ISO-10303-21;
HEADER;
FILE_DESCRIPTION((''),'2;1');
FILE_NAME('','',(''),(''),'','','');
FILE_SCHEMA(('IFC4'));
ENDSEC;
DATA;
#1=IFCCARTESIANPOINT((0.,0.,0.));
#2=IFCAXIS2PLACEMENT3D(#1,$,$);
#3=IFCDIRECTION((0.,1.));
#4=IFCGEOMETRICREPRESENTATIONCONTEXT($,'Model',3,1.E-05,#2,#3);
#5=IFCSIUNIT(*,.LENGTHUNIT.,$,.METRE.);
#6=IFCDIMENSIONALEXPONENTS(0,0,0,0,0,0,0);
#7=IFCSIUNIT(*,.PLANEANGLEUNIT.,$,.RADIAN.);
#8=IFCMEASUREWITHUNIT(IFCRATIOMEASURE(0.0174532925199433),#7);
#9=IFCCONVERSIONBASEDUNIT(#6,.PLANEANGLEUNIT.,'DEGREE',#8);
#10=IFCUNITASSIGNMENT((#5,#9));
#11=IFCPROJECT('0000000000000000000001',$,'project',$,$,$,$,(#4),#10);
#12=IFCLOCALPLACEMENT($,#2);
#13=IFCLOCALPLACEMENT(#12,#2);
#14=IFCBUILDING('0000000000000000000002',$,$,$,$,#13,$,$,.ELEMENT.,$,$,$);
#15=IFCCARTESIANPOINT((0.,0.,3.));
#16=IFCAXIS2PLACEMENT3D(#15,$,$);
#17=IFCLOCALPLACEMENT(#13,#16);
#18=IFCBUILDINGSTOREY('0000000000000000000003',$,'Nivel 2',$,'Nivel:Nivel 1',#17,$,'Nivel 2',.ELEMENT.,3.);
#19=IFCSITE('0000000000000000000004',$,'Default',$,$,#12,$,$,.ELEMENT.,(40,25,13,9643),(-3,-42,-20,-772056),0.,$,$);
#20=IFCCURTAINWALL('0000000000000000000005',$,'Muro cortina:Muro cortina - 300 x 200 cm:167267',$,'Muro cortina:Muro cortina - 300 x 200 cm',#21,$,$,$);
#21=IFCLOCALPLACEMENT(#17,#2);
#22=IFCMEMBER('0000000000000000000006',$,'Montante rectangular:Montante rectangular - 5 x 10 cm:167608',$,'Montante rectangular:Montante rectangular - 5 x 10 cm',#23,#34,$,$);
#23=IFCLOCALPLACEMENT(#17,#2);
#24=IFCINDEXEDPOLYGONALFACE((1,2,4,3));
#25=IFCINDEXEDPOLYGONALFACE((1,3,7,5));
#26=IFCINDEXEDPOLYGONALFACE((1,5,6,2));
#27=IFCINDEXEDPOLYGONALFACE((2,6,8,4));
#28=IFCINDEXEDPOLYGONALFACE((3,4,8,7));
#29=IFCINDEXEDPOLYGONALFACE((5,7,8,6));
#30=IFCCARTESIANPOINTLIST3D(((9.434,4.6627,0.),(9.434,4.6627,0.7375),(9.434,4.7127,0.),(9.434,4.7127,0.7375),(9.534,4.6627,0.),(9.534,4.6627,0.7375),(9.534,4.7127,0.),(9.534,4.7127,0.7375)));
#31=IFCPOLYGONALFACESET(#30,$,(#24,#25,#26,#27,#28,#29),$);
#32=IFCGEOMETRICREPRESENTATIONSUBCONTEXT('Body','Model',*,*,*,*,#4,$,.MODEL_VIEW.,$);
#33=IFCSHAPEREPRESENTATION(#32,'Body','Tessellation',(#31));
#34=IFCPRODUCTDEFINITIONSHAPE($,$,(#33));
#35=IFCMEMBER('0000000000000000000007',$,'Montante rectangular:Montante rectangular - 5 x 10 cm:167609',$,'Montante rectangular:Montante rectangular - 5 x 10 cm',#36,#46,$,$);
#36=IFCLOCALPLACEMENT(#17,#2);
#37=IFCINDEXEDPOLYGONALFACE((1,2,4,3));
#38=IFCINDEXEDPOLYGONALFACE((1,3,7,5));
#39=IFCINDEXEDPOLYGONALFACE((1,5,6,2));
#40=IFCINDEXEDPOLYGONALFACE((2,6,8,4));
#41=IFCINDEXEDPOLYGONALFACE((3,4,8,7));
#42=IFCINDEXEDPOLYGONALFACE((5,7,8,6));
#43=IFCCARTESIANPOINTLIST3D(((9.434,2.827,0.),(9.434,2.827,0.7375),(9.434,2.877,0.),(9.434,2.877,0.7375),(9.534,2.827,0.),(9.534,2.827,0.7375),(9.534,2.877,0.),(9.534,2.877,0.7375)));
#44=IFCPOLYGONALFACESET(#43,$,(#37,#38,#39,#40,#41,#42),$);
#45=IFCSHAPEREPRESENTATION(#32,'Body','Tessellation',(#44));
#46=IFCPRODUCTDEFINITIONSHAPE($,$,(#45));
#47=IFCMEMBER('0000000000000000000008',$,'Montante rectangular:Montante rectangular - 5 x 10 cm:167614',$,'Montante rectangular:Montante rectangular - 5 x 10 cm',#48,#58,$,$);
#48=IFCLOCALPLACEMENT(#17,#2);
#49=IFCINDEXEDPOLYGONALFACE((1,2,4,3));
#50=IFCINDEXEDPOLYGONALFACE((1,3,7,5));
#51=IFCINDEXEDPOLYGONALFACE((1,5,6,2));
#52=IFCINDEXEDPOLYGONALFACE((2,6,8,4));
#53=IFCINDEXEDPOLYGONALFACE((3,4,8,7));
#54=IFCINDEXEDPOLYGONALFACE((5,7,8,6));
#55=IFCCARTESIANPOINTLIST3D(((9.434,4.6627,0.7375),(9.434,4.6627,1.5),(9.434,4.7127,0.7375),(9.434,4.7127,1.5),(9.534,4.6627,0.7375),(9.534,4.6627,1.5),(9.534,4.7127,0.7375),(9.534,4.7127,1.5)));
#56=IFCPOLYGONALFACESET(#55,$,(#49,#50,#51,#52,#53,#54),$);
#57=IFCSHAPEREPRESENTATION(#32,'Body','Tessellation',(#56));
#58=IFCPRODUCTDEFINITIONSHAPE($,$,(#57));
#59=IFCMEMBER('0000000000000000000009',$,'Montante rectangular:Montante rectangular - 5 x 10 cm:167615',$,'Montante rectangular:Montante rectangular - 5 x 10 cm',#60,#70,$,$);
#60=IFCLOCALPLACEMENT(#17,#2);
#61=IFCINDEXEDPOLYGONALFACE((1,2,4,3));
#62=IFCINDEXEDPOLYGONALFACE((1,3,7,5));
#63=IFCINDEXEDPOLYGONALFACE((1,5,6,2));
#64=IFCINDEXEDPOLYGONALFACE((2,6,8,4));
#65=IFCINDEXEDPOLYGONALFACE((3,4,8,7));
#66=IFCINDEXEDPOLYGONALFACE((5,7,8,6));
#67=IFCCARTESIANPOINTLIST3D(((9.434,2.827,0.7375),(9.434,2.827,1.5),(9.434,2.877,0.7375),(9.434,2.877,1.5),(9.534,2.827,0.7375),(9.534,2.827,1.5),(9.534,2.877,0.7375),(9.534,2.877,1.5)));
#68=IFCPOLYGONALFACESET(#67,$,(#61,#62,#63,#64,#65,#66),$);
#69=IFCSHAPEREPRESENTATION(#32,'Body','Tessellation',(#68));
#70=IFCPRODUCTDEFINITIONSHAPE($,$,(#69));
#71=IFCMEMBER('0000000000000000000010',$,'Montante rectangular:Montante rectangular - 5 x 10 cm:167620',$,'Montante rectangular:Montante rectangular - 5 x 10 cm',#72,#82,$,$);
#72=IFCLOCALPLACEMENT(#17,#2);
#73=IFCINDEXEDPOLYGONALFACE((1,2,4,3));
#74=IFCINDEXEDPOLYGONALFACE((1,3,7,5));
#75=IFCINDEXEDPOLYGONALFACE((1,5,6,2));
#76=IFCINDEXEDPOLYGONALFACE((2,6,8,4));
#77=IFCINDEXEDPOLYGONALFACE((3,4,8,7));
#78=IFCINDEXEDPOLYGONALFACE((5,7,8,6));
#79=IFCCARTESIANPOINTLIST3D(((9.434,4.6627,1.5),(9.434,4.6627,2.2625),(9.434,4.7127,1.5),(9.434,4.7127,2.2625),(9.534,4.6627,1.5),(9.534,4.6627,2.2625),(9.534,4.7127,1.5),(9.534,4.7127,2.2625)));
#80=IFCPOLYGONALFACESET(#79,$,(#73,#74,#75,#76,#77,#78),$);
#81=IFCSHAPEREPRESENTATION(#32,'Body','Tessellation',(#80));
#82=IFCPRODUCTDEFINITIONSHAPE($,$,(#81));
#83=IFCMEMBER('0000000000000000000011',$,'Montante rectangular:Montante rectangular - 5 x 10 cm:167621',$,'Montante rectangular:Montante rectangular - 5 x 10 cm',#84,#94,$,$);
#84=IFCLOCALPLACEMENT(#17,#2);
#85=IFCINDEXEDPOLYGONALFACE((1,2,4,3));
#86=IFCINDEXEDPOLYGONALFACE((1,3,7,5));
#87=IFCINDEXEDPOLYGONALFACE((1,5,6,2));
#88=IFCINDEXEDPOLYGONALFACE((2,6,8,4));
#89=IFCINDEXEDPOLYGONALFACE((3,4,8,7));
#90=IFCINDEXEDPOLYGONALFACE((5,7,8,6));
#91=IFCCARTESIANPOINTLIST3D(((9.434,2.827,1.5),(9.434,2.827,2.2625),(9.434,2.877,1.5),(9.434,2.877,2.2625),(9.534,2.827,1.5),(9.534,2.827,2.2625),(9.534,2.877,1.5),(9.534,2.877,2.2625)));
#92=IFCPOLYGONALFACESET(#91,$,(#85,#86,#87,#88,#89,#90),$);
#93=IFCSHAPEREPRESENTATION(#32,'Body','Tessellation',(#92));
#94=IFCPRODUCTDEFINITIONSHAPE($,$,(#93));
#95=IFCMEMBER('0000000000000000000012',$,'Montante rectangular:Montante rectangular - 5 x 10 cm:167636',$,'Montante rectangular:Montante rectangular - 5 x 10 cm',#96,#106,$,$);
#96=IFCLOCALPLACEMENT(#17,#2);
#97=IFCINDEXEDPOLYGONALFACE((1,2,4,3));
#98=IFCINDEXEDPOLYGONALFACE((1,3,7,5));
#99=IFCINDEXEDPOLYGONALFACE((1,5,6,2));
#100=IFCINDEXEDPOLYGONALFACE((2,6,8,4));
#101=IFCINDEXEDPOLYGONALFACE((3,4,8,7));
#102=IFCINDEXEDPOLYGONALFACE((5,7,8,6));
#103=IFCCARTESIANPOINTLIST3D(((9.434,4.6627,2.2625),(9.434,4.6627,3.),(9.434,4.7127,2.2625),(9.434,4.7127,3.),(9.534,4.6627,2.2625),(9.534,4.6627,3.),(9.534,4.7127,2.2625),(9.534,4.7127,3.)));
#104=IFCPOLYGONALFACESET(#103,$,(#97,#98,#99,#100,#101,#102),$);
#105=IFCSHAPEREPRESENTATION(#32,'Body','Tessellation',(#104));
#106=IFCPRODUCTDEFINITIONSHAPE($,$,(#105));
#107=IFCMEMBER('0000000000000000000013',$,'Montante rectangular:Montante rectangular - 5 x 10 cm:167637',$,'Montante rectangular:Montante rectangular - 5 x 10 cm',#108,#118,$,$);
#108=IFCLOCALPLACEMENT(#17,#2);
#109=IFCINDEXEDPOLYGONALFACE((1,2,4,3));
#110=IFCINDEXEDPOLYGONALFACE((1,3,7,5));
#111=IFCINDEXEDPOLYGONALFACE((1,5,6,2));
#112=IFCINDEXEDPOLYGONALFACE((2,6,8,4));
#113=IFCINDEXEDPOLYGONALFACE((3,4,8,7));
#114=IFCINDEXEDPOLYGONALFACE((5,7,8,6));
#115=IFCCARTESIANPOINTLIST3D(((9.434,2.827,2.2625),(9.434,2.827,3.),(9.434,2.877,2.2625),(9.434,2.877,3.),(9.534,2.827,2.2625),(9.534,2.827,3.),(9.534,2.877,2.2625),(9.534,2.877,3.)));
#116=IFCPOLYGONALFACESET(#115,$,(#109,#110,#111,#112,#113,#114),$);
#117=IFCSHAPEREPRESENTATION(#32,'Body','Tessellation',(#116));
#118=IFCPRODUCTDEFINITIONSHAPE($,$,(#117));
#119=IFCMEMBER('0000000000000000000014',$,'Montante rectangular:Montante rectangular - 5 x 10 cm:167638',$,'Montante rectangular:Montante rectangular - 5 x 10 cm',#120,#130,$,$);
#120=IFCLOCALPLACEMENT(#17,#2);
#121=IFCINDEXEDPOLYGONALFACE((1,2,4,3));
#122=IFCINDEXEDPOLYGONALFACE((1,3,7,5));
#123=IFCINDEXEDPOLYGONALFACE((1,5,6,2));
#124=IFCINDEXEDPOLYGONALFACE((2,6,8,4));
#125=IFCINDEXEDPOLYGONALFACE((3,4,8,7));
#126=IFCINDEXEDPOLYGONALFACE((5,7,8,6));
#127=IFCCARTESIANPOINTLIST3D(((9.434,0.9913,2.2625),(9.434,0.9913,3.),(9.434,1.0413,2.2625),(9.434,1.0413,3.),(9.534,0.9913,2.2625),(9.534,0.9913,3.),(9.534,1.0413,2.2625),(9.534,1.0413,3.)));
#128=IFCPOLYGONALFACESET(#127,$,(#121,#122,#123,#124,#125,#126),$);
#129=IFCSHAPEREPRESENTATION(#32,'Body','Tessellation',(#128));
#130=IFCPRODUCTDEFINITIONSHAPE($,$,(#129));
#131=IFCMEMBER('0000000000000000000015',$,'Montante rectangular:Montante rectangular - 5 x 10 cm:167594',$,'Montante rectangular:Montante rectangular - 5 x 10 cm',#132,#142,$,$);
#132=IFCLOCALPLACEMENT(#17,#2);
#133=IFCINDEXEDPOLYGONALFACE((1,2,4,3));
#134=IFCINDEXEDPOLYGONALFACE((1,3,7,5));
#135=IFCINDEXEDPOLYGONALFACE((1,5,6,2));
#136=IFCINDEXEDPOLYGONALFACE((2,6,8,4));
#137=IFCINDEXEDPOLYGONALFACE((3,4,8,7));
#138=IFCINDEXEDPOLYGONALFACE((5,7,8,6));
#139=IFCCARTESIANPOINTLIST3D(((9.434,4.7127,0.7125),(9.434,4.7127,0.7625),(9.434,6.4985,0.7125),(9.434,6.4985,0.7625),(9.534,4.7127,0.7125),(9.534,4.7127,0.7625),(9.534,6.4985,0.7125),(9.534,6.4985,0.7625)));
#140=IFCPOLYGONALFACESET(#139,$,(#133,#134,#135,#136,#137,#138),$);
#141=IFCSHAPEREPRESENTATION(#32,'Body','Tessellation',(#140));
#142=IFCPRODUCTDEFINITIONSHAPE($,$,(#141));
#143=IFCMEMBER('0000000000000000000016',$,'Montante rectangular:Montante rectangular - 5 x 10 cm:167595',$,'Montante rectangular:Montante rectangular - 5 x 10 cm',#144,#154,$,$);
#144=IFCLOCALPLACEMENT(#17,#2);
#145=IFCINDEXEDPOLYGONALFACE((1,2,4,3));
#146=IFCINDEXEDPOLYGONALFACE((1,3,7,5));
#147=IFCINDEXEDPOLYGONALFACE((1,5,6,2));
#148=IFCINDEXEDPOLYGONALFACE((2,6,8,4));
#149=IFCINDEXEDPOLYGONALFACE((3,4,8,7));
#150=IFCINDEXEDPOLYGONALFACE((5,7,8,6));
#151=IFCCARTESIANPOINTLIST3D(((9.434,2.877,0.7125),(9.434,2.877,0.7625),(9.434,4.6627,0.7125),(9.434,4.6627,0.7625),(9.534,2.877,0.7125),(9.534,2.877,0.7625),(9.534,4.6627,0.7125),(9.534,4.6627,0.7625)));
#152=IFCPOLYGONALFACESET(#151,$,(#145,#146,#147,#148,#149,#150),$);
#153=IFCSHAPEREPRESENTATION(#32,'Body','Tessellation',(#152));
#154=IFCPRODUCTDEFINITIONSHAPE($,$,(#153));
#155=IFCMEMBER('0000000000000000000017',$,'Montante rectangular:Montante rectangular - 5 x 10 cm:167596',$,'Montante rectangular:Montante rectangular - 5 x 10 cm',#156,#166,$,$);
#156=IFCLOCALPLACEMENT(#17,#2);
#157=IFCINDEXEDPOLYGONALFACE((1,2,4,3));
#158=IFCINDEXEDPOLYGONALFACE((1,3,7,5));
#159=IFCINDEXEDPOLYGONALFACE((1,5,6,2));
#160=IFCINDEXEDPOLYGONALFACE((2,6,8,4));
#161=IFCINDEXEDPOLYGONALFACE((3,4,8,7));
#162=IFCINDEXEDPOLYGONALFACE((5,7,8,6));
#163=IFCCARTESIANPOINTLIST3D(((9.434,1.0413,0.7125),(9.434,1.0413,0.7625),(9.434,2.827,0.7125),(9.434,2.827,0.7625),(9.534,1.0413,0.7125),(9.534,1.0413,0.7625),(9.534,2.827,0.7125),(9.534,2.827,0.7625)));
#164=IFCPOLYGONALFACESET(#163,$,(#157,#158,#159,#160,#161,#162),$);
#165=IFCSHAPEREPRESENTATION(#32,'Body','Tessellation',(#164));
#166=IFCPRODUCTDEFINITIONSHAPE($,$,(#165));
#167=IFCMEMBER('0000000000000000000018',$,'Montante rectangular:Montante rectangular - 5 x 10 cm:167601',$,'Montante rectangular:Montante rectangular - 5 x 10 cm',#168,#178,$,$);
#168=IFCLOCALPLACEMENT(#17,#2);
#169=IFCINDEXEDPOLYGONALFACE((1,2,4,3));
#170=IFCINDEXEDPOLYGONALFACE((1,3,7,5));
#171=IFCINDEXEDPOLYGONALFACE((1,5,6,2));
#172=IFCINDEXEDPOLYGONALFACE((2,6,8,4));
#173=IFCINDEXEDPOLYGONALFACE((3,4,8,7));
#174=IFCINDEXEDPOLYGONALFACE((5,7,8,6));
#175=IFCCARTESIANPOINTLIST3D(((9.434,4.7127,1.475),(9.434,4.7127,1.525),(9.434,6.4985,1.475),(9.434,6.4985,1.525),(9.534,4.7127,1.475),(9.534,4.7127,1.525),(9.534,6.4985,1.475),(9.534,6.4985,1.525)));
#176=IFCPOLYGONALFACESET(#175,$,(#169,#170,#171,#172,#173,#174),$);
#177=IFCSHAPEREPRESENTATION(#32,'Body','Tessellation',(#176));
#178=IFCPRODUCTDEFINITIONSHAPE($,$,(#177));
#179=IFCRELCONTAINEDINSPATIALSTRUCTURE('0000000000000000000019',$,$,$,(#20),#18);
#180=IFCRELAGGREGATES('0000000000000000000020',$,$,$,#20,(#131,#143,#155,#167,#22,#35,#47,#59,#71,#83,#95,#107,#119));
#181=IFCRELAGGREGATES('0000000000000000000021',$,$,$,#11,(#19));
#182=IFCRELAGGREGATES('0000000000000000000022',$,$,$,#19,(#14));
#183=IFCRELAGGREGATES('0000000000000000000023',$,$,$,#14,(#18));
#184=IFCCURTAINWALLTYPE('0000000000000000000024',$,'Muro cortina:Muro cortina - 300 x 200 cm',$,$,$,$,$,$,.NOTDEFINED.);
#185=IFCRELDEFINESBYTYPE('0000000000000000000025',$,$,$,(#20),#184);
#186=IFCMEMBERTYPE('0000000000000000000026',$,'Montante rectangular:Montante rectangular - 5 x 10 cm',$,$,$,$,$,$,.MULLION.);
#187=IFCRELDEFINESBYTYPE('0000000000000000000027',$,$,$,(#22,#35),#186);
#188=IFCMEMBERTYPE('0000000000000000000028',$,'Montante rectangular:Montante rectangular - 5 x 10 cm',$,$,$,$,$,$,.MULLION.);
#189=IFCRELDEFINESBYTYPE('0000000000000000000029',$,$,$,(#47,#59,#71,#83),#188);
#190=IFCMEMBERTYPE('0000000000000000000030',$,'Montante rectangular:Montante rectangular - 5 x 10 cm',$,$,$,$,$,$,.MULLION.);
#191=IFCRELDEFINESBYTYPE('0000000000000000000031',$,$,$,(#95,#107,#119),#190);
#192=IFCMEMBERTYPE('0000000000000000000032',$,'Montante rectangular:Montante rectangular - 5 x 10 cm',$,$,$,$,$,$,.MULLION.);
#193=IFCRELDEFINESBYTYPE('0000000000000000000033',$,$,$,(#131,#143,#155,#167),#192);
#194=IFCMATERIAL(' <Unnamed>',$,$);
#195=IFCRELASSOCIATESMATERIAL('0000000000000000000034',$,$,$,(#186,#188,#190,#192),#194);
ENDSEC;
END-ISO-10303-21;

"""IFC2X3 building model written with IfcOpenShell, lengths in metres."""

from ifc_helpers import new_model, entity, si_unit, converted_unit, direction, frame, origin, origin_2d_with_axis, place, context, subcontext, project, spatial, rectangle, extrude, source, transform, mapped, material, type_object, type_shapes, element, aggregate, save


model = new_model("IFC2X3")

# Units and contexts
model_context = context("Model", 3, precision=1e-05, world=origin(), true_north=direction((0.0, 1.0)))
body_context = subcontext(model_context, "Body", "Model", "MODEL_VIEW")
ifc_project = project(units=[si_unit("LENGTHUNIT", "METRE"), converted_unit("PLANEANGLEUNIT", "DEGREE", entity("IfcRatioMeasure", 0.0174532925199433), si_unit("PLANEANGLEUNIT", "RADIAN"), dimensions=[0, 0, 0, 0, 0, 0, 0])], contexts=[model_context])

# Site, building, storey
site_placement = place(None, origin())
site = spatial("IfcSite", under=ifc_project, at=site_placement, Name="Default", CompositionType="ELEMENT", RefLatitude=(40, 25, 13, 9643), RefLongitude=(-3, -42, -20, -772056), RefElevation=0.0)
building_placement = place(site_placement, origin())
building = spatial("IfcBuilding", under=site, at=building_placement, CompositionType="ELEMENT")
storey_placement = place(building_placement, frame((0.0, 0.0, 3.0)))
storey = spatial("IfcBuildingStorey", under=building, at=storey_placement, Name="Nivel 2", ObjectType="Nivel:Nivel 1", LongName="Nivel 2", CompositionType="ELEMENT", Elevation=3.0)

# Curtain wall, members
curtain_wall_type = type_object("IfcCurtainWallType", Name="Muro cortina:Muro cortina - 300 x 200 cm", PredefinedType="NOTDEFINED")
curtain_wall_placement = place(storey_placement, frame((0.0, 0.0, -3.0)))
curtain_wall = element("IfcCurtainWall", 1, at=curtain_wall_placement, inside=storey, type_object=curtain_wall_type, Name="Muro cortina:Muro cortina - 300 x 200 cm:167267", ObjectType="Muro cortina:Muro cortina - 300 x 200 cm")
ifc_material_1 = material(Name=" <Unnamed>")
member_type_1 = type_object("IfcMemberType", Name="Montante rectangular:Montante rectangular - 5 x 10 cm", PredefinedType="MULLION", material=ifc_material_1)
shared_shape_1 = source(origin(), body_context, "Body", "SweptSolid", [
    extrude(rectangle(XDim=0.1, YDim=0.05, at=origin_2d_with_axis()), frame((0.0, 0.0, -0.7375), z_axis=(0.0, 0.0, 1.0), x_axis=(0.0, -1.0, 0.0)), (0.0, 0.0, 1.0), 0.7375),
])
type_shapes(member_type_1, [shared_shape_1])
member_1_placement = place(storey_placement, frame((9.484, 4.6877, 0.0), z_axis=(0.0, 0.0, -1.0), x_axis=(0.0, -1.0, 0.0)))
member_1 = element("IfcMember", 2, at=member_1_placement, type_object=member_type_1, Name="Montante rectangular:Montante rectangular - 5 x 10 cm:167608", ObjectType="Montante rectangular:Montante rectangular - 5 x 10 cm", context=body_context, shape_type="MappedRepresentation", body=[
    mapped(shared_shape_1, transform((0.0, 0.0, 0.0), scale=1.0)),
])
member_2_placement = place(storey_placement, frame((9.484, 2.852, 0.0), z_axis=(0.0, 0.0, -1.0), x_axis=(0.0, -1.0, 0.0)))
member_2 = element("IfcMember", 3, at=member_2_placement, type_object=member_type_1, Name="Montante rectangular:Montante rectangular - 5 x 10 cm:167609", ObjectType="Montante rectangular:Montante rectangular - 5 x 10 cm", context=body_context, shape_type="MappedRepresentation", body=[
    mapped(shared_shape_1, transform((0.0, 0.0, 0.0), scale=1.0)),
])
member_type_2 = type_object("IfcMemberType", Name="Montante rectangular:Montante rectangular - 5 x 10 cm", PredefinedType="MULLION", material=ifc_material_1)
shared_shape_2 = source(origin(), body_context, "Body", "SweptSolid", [
    extrude(rectangle(XDim=0.1, YDim=0.05, at=origin_2d_with_axis()), frame((0.0, 0.0, -0.7625), z_axis=(0.0, 0.0, 1.0), x_axis=(0.0, -1.0, 0.0)), (0.0, 0.0, 1.0), 0.7625),
])
type_shapes(member_type_2, [shared_shape_2])
member_3_placement = place(storey_placement, frame((9.484, 4.6877, 0.7375), z_axis=(0.0, 0.0, -1.0), x_axis=(0.0, -1.0, 0.0)))
member_3 = element("IfcMember", 4, at=member_3_placement, type_object=member_type_2, Name="Montante rectangular:Montante rectangular - 5 x 10 cm:167614", ObjectType="Montante rectangular:Montante rectangular - 5 x 10 cm", context=body_context, shape_type="MappedRepresentation", body=[
    mapped(shared_shape_2, transform((0.0, 0.0, 0.0), scale=1.0)),
])
member_4_placement = place(storey_placement, frame((9.484, 2.852, 0.7375), z_axis=(0.0, 0.0, -1.0), x_axis=(0.0, -1.0, 0.0)))
member_4 = element("IfcMember", 5, at=member_4_placement, type_object=member_type_2, Name="Montante rectangular:Montante rectangular - 5 x 10 cm:167615", ObjectType="Montante rectangular:Montante rectangular - 5 x 10 cm", context=body_context, shape_type="MappedRepresentation", body=[
    mapped(shared_shape_2, transform((0.0, 0.0, 0.0), scale=1.0)),
])
member_5_placement = place(storey_placement, frame((9.484, 4.6877, 1.5), z_axis=(0.0, 0.0, -1.0), x_axis=(0.0, -1.0, 0.0)))
member_5 = element("IfcMember", 6, at=member_5_placement, type_object=member_type_2, Name="Montante rectangular:Montante rectangular - 5 x 10 cm:167620", ObjectType="Montante rectangular:Montante rectangular - 5 x 10 cm", context=body_context, shape_type="MappedRepresentation", body=[
    mapped(shared_shape_2, transform((0.0, 0.0, 0.0), scale=1.0)),
])
member_6_placement = place(storey_placement, frame((9.484, 2.852, 1.5), z_axis=(0.0, 0.0, -1.0), x_axis=(0.0, -1.0, 0.0)))
member_6 = element("IfcMember", 7, at=member_6_placement, type_object=member_type_2, Name="Montante rectangular:Montante rectangular - 5 x 10 cm:167621", ObjectType="Montante rectangular:Montante rectangular - 5 x 10 cm", context=body_context, shape_type="MappedRepresentation", body=[
    mapped(shared_shape_2, transform((0.0, 0.0, 0.0), scale=1.0)),
])
member_type_3 = type_object("IfcMemberType", Name="Montante rectangular:Montante rectangular - 5 x 10 cm", PredefinedType="MULLION", material=ifc_material_1)
shared_shape_3 = source(origin(), body_context, "Body", "SweptSolid", [
    extrude(rectangle(XDim=0.1, YDim=0.05, at=origin_2d_with_axis()), frame((0.0, 0.0, -0.7375), z_axis=(0.0, 0.0, 1.0), x_axis=(0.0, -1.0, 0.0)), (0.0, 0.0, 1.0), 0.7375),
])
type_shapes(member_type_3, [shared_shape_3])
member_7_placement = place(storey_placement, frame((9.484, 4.6877, 2.2625), z_axis=(0.0, 0.0, -1.0), x_axis=(0.0, -1.0, 0.0)))
member_7 = element("IfcMember", 8, at=member_7_placement, type_object=member_type_3, Name="Montante rectangular:Montante rectangular - 5 x 10 cm:167636", ObjectType="Montante rectangular:Montante rectangular - 5 x 10 cm", context=body_context, shape_type="MappedRepresentation", body=[
    mapped(shared_shape_3, transform((0.0, 0.0, 0.0), scale=1.0)),
])
member_8_placement = place(storey_placement, frame((9.484, 2.852, 2.2625), z_axis=(0.0, 0.0, -1.0), x_axis=(0.0, -1.0, 0.0)))
member_8 = element("IfcMember", 9, at=member_8_placement, type_object=member_type_3, Name="Montante rectangular:Montante rectangular - 5 x 10 cm:167637", ObjectType="Montante rectangular:Montante rectangular - 5 x 10 cm", context=body_context, shape_type="MappedRepresentation", body=[
    mapped(shared_shape_3, transform((0.0, 0.0, 0.0), scale=1.0)),
])
member_9_placement = place(storey_placement, frame((9.484, 1.0163, 2.2625), z_axis=(0.0, 0.0, -1.0), x_axis=(0.0, -1.0, 0.0)))
member_9 = element("IfcMember", 10, at=member_9_placement, type_object=member_type_3, Name="Montante rectangular:Montante rectangular - 5 x 10 cm:167638", ObjectType="Montante rectangular:Montante rectangular - 5 x 10 cm", context=body_context, shape_type="MappedRepresentation", body=[
    mapped(shared_shape_3, transform((0.0, 0.0, 0.0), scale=1.0)),
])
member_type_4 = type_object("IfcMemberType", Name="Montante rectangular:Montante rectangular - 5 x 10 cm", PredefinedType="MULLION", material=ifc_material_1)
shared_shape_4 = source(origin(), body_context, "Body", "SweptSolid", [
    extrude(rectangle(XDim=0.1, YDim=0.05, at=origin_2d_with_axis()), frame((0.0, 0.0, -1.7857), z_axis=(0.0, 0.0, 1.0), x_axis=(0.0, -1.0, 0.0)), (0.0, 0.0, 1.0), 1.7857),
])
type_shapes(member_type_4, [shared_shape_4])
member_10_placement = place(storey_placement, frame((9.484, 4.7127, 0.7375), z_axis=(0.0, -1.0, 0.0), x_axis=(0.0, 0.0, 1.0)))
member_10 = element("IfcMember", 11, at=member_10_placement, type_object=member_type_4, Name="Montante rectangular:Montante rectangular - 5 x 10 cm:167594", ObjectType="Montante rectangular:Montante rectangular - 5 x 10 cm", context=body_context, shape_type="MappedRepresentation", body=[
    mapped(shared_shape_4, transform((0.0, 0.0, 0.0), scale=1.0)),
])
member_11_placement = place(storey_placement, frame((9.484, 2.877, 0.7375), z_axis=(0.0, -1.0, 0.0), x_axis=(0.0, 0.0, 1.0)))
member_11 = element("IfcMember", 12, at=member_11_placement, type_object=member_type_4, Name="Montante rectangular:Montante rectangular - 5 x 10 cm:167595", ObjectType="Montante rectangular:Montante rectangular - 5 x 10 cm", context=body_context, shape_type="MappedRepresentation", body=[
    mapped(shared_shape_4, transform((0.0, 0.0, 0.0), scale=1.0)),
])
member_12_placement = place(storey_placement, frame((9.484, 1.0413, 0.7375), z_axis=(0.0, -1.0, 0.0), x_axis=(0.0, 0.0, 1.0)))
member_12 = element("IfcMember", 13, at=member_12_placement, type_object=member_type_4, Name="Montante rectangular:Montante rectangular - 5 x 10 cm:167596", ObjectType="Montante rectangular:Montante rectangular - 5 x 10 cm", context=body_context, shape_type="MappedRepresentation", body=[
    mapped(shared_shape_4, transform((0.0, 0.0, 0.0), scale=1.0)),
])
member_13_placement = place(storey_placement, frame((9.484, 4.7127, 1.5), z_axis=(0.0, -1.0, 0.0), x_axis=(0.0, 0.0, 1.0)))
member_13 = element("IfcMember", 14, at=member_13_placement, type_object=member_type_4, Name="Montante rectangular:Montante rectangular - 5 x 10 cm:167601", ObjectType="Montante rectangular:Montante rectangular - 5 x 10 cm", context=body_context, shape_type="MappedRepresentation", body=[
    mapped(shared_shape_4, transform((0.0, 0.0, 0.0), scale=1.0)),
])
aggregate(curtain_wall, [member_10, member_11, member_12, member_13, member_1, member_2, member_3, member_4, member_5, member_6, member_7, member_8, member_9])

save(model, "model.ifc")
